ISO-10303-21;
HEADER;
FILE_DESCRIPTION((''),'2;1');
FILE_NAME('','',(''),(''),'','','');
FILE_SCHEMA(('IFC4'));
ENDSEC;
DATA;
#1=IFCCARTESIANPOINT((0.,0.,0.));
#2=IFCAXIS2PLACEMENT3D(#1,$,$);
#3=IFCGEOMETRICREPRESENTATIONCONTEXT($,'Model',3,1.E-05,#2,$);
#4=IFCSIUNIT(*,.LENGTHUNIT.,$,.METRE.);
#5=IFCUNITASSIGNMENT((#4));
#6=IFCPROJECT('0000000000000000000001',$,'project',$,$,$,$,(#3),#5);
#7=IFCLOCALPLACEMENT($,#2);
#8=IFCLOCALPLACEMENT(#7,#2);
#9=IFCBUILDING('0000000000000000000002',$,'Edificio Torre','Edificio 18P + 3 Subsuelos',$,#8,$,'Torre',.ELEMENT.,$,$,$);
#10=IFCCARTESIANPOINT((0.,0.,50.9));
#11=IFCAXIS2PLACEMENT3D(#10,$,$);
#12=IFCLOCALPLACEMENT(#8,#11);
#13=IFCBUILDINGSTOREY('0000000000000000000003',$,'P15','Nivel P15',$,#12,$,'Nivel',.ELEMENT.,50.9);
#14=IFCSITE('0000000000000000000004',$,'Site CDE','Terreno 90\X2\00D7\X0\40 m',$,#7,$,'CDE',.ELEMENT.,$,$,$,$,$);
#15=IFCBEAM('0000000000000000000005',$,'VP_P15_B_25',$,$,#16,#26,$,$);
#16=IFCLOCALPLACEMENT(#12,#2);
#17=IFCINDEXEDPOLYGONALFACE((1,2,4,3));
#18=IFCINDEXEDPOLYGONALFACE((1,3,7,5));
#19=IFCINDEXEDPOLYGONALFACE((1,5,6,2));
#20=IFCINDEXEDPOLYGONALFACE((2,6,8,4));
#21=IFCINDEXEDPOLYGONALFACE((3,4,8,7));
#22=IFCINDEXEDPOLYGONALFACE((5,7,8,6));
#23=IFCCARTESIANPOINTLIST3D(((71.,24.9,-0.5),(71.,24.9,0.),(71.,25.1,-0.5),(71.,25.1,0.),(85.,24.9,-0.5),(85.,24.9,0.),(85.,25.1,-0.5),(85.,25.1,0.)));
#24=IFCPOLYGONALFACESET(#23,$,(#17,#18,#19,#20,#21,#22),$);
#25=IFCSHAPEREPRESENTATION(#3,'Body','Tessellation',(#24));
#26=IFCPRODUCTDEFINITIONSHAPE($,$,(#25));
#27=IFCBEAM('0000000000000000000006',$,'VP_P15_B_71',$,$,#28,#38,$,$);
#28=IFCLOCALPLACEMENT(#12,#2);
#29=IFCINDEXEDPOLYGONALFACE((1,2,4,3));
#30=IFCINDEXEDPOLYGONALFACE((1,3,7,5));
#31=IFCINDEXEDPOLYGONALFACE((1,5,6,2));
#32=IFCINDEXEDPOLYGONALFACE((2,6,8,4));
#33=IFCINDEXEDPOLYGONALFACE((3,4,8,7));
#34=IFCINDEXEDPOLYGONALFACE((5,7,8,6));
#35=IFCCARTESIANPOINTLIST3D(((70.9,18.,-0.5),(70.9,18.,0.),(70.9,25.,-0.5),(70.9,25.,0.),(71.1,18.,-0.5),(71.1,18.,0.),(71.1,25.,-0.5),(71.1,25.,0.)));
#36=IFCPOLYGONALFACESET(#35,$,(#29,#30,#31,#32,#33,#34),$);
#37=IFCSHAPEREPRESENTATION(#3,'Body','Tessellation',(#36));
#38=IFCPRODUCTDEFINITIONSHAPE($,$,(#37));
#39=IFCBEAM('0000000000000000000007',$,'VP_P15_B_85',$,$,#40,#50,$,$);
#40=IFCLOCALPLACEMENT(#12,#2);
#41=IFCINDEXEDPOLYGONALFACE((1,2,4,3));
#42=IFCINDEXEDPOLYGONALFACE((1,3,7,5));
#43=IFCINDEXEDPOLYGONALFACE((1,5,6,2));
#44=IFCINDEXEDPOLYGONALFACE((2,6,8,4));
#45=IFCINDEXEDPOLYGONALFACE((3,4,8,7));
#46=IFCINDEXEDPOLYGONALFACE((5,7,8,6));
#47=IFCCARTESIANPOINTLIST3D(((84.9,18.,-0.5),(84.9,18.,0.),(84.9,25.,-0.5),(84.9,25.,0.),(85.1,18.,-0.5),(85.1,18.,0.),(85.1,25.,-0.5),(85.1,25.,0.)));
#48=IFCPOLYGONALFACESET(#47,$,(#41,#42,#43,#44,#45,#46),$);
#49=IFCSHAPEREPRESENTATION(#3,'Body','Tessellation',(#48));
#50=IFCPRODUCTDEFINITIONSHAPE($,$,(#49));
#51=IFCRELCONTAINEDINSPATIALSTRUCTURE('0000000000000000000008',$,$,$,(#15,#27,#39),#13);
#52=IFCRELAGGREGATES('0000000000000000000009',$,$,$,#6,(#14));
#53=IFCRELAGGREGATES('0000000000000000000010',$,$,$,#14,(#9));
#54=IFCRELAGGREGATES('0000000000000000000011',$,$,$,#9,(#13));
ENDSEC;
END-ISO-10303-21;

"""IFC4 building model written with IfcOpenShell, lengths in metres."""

from ifc_helpers import new_model, si_unit, frame, origin, origin_2d, place, context, project, spatial, rectangle, extrude, element, save


model = new_model("IFC4")

# Units and contexts
model_context = context("Model", 3, precision=1e-05, world=origin())
ifc_project = project(units=[si_unit("LENGTHUNIT", "METRE")], contexts=[model_context])

# Site, building, storey
site_placement = place(None, origin())
site = spatial("IfcSite", under=ifc_project, at=site_placement, Name="Site CDE", Description="Terreno 90×40 m", LongName="CDE", CompositionType="ELEMENT")
building_placement = place(site_placement, origin())
building = spatial("IfcBuilding", under=site, at=building_placement, Name="Edificio Torre", Description="Edificio 18P + 3 Subsuelos", LongName="Torre", CompositionType="ELEMENT")
storey_placement = place(building_placement, frame((0.0, 0.0, 50.9)))
storey = spatial("IfcBuildingStorey", under=building, at=storey_placement, Name="P15", Description="Nivel P15", LongName="Nivel", CompositionType="ELEMENT", Elevation=50.9)

# Beams
for number, where, name in (
    (1, (78.0, 25.0, -0.5), "VP_P15_B_25"),
):
    element("IfcBeam", number, at=place(storey_placement, frame(where)), inside=storey, Name=name, context=model_context, shape_type="SweptSolid", body=[
        extrude(rectangle(XDim=14.0, YDim=0.2, at=origin_2d()), origin(), (0.0, 0.0, 1.0), 0.5),
    ])
for number, where, name in (
    (2, (71.0, 21.5, -0.5), "VP_P15_B_71"),
    (3, (85.0, 21.5, -0.5), "VP_P15_B_85"),
):
    element("IfcBeam", number, at=place(storey_placement, frame(where)), inside=storey, Name=name, context=model_context, shape_type="SweptSolid", body=[
        extrude(rectangle(XDim=0.2, YDim=7.0, at=origin_2d()), origin(), (0.0, 0.0, 1.0), 0.5),
    ])

save(model, "model.ifc")
